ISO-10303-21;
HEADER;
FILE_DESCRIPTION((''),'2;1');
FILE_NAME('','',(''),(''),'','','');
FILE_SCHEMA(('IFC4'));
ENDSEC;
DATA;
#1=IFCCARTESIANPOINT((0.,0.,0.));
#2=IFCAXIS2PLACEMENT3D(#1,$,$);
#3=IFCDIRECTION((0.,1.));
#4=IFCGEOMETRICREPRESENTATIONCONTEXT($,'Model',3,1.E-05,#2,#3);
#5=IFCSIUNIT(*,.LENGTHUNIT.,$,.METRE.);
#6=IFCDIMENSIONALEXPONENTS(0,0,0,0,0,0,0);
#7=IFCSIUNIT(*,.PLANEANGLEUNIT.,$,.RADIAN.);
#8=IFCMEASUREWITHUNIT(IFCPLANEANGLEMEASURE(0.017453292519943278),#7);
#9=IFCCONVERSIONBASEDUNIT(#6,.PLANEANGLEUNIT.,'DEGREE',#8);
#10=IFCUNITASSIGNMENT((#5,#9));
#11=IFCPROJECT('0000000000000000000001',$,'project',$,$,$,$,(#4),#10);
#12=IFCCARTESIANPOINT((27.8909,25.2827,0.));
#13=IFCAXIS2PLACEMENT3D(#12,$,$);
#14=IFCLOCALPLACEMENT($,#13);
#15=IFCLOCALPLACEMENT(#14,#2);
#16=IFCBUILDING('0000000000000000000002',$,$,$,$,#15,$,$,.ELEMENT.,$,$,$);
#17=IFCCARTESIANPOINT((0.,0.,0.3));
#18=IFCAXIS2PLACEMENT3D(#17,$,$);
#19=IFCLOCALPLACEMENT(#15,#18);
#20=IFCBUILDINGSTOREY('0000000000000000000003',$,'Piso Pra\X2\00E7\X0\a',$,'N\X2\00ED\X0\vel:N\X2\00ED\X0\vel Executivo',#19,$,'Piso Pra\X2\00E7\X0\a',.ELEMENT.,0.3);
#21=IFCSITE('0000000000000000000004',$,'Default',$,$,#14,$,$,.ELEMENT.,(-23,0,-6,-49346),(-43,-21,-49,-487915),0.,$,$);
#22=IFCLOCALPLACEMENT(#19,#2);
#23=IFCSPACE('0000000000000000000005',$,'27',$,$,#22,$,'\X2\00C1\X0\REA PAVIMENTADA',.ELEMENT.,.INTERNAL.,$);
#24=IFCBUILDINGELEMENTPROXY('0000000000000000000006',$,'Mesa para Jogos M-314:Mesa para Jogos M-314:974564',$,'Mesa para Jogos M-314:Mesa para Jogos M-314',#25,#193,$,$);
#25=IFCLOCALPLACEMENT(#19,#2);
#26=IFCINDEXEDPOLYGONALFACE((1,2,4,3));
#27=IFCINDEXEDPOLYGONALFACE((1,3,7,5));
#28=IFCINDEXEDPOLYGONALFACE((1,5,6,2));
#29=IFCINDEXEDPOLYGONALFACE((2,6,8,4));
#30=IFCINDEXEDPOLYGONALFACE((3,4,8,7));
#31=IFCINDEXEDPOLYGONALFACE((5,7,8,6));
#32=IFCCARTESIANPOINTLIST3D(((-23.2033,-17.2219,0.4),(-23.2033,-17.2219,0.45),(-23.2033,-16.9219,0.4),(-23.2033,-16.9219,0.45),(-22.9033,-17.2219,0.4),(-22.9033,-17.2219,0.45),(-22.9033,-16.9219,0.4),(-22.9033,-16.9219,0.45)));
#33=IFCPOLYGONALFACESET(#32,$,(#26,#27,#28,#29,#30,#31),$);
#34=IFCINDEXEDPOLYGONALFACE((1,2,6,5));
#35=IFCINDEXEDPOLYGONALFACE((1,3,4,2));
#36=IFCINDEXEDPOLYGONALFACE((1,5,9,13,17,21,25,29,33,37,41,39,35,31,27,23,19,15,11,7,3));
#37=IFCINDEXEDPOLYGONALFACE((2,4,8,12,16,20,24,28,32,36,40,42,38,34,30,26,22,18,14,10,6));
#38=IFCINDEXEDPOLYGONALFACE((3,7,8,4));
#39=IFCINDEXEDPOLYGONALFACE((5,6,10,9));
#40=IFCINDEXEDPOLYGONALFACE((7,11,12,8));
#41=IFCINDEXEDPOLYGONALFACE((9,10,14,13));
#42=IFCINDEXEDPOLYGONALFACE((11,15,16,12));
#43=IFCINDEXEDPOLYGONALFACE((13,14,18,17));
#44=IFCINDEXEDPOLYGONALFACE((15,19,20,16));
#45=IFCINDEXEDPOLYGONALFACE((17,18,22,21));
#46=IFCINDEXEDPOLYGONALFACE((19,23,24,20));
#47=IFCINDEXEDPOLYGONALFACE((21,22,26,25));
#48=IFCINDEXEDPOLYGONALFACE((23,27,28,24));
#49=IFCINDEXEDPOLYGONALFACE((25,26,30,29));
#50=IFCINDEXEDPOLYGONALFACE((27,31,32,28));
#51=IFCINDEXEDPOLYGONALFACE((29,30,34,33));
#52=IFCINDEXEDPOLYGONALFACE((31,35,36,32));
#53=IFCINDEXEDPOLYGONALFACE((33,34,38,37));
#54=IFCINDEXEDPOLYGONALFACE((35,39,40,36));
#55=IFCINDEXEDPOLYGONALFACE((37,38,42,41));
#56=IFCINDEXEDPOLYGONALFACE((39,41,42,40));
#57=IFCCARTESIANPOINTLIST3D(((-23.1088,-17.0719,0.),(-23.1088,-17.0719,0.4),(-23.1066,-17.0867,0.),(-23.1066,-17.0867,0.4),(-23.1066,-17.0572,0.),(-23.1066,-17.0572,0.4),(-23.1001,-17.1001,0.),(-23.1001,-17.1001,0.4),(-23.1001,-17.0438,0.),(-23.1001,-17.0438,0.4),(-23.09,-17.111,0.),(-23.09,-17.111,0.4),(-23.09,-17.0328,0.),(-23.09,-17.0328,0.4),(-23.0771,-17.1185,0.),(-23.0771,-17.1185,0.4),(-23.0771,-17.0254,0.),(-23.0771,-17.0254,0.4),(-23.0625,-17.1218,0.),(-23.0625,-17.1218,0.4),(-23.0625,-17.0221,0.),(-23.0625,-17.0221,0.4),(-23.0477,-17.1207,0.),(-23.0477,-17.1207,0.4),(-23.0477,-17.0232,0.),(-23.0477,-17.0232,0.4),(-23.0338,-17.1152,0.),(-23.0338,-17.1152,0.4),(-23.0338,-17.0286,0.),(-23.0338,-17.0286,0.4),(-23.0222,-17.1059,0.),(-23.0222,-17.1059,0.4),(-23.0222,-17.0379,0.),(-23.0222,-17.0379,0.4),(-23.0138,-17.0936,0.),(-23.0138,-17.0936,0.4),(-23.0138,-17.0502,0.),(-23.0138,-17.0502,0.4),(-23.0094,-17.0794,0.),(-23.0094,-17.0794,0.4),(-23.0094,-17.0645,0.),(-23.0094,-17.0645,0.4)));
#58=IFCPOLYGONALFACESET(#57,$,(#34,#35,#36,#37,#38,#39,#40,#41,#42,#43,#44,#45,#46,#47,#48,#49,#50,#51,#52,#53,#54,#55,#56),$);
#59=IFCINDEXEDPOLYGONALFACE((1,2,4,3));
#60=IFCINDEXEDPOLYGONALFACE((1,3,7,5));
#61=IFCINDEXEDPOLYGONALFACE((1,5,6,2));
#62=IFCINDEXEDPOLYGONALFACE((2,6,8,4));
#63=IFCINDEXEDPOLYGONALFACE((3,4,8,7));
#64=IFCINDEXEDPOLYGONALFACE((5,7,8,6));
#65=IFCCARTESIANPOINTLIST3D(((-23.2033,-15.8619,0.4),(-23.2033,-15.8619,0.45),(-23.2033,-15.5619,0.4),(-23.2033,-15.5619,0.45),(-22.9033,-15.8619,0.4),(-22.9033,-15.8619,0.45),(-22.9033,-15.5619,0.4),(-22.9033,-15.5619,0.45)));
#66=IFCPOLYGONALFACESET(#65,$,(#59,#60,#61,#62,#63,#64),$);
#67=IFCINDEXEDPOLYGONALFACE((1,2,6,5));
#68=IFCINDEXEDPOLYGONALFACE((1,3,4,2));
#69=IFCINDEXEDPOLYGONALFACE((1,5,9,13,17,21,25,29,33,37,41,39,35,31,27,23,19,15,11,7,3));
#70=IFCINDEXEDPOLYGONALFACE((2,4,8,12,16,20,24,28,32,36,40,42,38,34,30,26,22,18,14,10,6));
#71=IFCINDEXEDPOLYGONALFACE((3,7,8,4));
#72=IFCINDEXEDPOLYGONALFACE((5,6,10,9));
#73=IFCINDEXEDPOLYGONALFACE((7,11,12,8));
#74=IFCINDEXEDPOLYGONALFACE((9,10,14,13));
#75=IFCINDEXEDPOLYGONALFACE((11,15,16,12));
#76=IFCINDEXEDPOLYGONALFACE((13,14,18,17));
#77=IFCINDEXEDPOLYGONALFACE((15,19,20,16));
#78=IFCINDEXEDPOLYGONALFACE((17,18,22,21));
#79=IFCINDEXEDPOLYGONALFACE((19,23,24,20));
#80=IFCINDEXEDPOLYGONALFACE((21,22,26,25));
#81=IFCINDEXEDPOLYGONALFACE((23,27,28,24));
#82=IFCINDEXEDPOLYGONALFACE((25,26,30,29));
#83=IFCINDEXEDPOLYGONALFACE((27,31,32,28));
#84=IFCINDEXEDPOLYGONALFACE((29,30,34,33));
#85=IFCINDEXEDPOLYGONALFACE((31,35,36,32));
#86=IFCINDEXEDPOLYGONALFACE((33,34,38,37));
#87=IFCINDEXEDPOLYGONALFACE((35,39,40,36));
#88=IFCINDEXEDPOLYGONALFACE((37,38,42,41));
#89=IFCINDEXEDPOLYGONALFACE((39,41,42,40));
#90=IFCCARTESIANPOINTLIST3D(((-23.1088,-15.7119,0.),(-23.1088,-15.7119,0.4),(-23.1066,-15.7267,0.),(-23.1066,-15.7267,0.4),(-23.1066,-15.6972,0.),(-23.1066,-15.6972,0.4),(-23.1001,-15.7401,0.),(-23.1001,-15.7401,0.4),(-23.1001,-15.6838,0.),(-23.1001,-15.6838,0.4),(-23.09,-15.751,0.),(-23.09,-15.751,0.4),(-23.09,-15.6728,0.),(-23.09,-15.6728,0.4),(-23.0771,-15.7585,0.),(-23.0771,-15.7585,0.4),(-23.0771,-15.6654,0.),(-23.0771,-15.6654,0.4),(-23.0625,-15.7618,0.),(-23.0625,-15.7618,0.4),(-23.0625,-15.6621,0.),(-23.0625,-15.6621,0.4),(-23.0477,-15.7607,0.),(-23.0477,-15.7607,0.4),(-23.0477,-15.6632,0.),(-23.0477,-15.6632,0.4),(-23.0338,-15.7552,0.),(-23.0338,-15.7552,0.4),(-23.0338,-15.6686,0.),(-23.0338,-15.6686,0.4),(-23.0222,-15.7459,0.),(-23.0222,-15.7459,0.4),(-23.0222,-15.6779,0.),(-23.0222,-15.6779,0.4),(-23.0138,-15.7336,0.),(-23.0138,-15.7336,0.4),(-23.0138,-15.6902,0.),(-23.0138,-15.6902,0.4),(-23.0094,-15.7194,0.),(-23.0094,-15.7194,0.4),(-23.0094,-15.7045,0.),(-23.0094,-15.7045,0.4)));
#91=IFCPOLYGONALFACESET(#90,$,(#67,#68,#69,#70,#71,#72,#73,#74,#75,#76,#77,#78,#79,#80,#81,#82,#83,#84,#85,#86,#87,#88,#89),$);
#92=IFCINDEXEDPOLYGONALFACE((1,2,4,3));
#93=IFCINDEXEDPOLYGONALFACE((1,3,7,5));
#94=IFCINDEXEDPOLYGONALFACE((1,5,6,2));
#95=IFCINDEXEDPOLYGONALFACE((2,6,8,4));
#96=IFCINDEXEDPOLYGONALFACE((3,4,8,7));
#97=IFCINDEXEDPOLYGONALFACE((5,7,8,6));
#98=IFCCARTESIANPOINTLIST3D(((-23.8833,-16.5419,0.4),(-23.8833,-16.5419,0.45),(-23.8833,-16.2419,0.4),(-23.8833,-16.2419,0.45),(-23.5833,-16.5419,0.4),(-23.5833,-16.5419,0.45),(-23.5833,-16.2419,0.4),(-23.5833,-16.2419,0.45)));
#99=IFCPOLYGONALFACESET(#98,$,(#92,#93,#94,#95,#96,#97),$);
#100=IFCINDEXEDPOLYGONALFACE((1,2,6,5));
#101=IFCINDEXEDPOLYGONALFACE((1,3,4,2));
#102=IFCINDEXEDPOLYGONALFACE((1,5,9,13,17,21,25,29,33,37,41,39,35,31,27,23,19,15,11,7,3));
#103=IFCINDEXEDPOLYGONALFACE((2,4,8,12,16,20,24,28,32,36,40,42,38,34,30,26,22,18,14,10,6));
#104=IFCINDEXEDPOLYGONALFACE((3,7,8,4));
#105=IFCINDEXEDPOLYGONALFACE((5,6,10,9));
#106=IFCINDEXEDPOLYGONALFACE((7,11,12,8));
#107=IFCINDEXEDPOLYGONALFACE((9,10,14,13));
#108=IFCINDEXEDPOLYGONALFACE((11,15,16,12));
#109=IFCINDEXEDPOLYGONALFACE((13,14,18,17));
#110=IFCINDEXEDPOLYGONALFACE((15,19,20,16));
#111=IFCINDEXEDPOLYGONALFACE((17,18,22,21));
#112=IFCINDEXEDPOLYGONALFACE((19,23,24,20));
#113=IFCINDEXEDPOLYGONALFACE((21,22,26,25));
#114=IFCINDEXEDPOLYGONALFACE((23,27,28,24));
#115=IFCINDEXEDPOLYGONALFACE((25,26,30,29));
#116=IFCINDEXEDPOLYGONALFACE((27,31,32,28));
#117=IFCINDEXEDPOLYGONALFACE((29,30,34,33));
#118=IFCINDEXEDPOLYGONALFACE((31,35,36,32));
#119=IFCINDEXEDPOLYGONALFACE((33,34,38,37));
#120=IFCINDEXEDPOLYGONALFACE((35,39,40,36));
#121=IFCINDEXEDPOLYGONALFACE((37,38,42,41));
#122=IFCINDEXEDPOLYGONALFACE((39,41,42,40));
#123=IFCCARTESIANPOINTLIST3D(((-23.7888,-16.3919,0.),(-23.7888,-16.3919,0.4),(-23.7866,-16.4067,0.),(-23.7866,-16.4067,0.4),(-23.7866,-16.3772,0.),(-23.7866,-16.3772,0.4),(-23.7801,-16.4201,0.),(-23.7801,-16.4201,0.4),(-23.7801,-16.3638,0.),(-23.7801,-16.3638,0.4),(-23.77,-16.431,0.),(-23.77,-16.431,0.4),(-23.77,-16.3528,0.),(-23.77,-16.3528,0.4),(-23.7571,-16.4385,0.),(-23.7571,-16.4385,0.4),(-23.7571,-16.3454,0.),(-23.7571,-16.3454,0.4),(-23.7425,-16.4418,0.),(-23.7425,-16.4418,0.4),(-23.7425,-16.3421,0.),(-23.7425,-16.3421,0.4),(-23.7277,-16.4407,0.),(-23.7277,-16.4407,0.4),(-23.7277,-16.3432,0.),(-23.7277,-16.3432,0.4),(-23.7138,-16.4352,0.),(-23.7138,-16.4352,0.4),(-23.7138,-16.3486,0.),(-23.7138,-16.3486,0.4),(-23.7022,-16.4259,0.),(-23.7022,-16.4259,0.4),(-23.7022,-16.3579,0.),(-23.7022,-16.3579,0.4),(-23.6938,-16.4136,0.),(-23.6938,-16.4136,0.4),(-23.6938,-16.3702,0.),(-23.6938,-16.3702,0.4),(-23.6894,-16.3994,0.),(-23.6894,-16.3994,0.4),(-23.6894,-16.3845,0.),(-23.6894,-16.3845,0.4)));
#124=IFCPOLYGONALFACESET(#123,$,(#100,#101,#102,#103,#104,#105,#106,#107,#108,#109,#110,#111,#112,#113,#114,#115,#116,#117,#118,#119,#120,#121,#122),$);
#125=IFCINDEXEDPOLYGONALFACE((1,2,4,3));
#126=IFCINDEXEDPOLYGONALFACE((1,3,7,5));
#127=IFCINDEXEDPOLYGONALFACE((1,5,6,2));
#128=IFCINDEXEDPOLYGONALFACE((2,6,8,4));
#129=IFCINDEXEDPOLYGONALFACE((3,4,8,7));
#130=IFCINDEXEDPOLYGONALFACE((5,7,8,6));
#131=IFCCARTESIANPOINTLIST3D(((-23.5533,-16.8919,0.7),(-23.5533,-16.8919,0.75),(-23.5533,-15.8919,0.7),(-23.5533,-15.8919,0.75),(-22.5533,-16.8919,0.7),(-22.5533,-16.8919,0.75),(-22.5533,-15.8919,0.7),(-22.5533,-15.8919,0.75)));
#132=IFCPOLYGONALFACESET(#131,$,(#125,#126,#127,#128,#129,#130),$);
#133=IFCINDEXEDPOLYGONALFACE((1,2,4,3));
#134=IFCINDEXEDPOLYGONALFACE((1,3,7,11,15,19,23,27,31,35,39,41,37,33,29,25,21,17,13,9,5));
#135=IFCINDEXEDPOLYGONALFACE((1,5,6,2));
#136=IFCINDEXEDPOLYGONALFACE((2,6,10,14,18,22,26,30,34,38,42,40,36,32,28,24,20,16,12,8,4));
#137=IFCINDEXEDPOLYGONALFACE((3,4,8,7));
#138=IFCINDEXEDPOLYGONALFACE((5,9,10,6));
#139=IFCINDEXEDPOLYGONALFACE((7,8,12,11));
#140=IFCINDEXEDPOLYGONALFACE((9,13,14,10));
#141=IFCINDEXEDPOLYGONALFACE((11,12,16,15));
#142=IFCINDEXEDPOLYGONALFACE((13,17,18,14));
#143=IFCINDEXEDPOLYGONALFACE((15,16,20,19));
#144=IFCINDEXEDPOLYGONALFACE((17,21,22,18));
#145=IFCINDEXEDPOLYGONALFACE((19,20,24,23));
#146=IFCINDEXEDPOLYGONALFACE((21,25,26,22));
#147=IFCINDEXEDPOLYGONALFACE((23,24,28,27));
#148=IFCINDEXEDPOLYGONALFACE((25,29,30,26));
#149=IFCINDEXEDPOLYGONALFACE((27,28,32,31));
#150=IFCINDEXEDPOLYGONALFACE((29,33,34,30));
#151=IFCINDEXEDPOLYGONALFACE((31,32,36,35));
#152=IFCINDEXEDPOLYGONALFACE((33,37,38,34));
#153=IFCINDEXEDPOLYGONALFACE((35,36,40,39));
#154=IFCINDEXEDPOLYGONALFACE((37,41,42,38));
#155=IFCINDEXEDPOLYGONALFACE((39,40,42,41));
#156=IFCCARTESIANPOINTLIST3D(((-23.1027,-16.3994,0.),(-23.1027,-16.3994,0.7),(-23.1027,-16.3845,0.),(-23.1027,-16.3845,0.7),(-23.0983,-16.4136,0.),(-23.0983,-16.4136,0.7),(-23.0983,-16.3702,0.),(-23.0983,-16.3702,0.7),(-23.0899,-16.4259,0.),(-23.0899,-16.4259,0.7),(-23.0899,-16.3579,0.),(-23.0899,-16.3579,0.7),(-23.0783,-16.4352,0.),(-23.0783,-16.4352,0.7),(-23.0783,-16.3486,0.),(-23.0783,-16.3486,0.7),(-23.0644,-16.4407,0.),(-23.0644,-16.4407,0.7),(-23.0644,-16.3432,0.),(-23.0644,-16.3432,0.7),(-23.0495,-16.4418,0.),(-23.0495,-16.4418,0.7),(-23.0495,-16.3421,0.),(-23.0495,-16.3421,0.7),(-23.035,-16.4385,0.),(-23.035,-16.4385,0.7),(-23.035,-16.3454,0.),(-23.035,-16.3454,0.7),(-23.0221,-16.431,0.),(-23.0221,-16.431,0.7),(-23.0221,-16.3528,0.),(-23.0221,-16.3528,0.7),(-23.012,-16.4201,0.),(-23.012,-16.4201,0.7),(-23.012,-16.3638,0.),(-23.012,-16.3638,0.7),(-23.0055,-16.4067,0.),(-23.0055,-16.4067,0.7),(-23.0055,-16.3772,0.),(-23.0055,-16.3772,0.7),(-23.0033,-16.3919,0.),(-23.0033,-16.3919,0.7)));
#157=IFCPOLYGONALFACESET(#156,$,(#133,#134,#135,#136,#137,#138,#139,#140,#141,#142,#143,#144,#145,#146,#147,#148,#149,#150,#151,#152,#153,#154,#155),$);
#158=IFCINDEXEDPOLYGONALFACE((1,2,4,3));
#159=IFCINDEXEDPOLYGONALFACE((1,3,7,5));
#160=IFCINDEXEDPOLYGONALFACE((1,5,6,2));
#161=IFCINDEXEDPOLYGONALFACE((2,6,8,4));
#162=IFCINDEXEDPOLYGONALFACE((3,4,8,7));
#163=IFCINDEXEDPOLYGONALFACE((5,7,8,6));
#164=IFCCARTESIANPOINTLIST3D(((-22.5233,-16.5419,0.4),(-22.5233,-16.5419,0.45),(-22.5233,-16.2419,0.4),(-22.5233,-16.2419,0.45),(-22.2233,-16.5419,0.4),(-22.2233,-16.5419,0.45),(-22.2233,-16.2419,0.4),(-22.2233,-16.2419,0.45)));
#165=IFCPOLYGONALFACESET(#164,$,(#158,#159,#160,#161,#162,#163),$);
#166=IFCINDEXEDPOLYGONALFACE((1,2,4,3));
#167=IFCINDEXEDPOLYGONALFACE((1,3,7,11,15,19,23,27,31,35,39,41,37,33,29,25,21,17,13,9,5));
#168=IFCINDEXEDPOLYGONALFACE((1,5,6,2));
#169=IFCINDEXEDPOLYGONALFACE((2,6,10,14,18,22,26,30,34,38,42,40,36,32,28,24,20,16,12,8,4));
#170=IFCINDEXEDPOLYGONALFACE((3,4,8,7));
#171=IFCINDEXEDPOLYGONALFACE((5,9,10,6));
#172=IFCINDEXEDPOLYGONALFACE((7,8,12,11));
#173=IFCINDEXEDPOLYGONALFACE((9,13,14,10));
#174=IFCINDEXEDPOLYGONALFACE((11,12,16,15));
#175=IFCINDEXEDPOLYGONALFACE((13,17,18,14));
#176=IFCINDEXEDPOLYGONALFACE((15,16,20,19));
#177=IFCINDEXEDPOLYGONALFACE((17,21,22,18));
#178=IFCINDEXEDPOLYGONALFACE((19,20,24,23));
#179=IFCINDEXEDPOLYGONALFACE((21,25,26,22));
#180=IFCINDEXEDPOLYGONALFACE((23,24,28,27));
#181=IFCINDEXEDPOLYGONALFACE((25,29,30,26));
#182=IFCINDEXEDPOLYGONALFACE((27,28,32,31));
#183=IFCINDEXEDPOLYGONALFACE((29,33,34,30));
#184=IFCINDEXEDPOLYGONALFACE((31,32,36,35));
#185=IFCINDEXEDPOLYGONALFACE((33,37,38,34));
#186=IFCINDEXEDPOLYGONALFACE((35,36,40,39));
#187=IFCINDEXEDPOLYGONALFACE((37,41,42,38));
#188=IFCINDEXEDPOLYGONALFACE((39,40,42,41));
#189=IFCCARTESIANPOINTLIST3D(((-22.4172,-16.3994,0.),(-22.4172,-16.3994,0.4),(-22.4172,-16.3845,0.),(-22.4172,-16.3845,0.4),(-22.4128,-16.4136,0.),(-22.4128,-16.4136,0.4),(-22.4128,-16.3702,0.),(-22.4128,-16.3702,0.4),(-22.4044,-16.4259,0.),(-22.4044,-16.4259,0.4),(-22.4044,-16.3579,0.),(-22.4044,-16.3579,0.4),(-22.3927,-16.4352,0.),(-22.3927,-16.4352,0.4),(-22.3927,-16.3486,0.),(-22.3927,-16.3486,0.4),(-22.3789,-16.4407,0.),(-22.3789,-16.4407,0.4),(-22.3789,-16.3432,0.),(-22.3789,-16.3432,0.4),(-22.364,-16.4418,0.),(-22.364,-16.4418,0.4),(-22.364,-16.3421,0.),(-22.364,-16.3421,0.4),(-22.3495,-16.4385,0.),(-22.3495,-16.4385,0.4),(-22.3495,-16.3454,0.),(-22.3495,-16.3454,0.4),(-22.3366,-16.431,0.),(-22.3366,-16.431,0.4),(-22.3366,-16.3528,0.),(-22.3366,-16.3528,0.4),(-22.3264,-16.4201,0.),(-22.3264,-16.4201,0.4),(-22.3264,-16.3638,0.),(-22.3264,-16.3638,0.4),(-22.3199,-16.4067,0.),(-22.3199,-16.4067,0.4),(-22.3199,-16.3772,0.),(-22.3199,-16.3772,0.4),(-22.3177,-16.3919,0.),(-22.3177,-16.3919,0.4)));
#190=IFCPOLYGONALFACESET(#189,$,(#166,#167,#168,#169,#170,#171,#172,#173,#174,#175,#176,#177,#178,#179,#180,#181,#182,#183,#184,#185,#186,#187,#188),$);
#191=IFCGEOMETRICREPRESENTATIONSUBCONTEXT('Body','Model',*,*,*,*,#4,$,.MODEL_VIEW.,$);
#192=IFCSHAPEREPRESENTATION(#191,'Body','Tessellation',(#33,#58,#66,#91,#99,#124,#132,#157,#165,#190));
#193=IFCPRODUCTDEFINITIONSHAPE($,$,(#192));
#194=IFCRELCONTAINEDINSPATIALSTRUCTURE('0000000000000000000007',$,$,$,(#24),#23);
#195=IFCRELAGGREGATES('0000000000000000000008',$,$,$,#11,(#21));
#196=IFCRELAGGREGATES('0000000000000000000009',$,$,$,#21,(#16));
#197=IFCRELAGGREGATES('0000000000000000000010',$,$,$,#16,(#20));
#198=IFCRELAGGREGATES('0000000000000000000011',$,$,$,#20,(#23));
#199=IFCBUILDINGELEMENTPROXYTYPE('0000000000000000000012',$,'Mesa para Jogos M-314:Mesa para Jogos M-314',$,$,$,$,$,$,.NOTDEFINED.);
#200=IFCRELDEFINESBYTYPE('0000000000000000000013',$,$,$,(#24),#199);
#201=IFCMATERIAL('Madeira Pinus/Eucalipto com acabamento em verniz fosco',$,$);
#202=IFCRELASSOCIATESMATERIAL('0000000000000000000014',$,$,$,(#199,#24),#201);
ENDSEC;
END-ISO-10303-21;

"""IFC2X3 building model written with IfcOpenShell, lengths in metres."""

from ifc_helpers import new_model, entity, si_unit, converted_unit, direction, frame, frame_2d, origin, place, context, subcontext, project, spatial, rectangle, circle, extrude, source, transform, mapped, material, type_object, type_shapes, element, save


model = new_model("IFC2X3")

# Units and contexts
model_context = context("Model", 3, precision=1e-05, world=origin(), true_north=direction((0.0, 1.0)))
body_context = subcontext(model_context, "Body", "Model", "MODEL_VIEW")
ifc_project = project(units=[si_unit("LENGTHUNIT", "METRE"), converted_unit("PLANEANGLEUNIT", "DEGREE", entity("IfcPlaneAngleMeasure", 0.017453292519943278), si_unit("PLANEANGLEUNIT", "RADIAN"), dimensions=[0, 0, 0, 0, 0, 0, 0])], contexts=[model_context])

# Site, building, storey
site_placement = place(None, frame((27.8909, 25.2827, 0.0)))
site = spatial("IfcSite", under=ifc_project, at=site_placement, Name="Default", CompositionType="ELEMENT", RefLatitude=(-23, 0, -6, -49346), RefLongitude=(-43, -21, -49, -487915), RefElevation=0.0)
building_placement = place(site_placement, origin())
building = spatial("IfcBuilding", under=site, at=building_placement, CompositionType="ELEMENT")
storey_placement = place(building_placement, frame((0.0, 0.0, 0.3)))
storey = spatial("IfcBuildingStorey", under=building, at=storey_placement, Name="Piso Praça", ObjectType="Nível:Nível Executivo", LongName="Piso Praça", CompositionType="ELEMENT", Elevation=0.3)

# Shared definitions
ifc_material_1 = material(Name="Madeira Pinus/Eucalipto com acabamento em verniz fosco")

# Shared definitions
space_1_placement = place(storey_placement, origin())
space_1 = spatial("IfcSpace", under=storey, at=space_1_placement, Name="27", LongName="ÁREA PAVIMENTADA", CompositionType="ELEMENT", InteriorOrExteriorSpace="INTERNAL")

# Building element proxy
building_element_proxy_type_1 = type_object("IfcBuildingElementProxyType", Name="Mesa para Jogos M-314:Mesa para Jogos M-314", PredefinedType="NOTDEFINED", material=ifc_material_1)
shared_shape_1 = source(origin(), body_context, "Body", "SweptSolid", [
    extrude(rectangle(XDim=0.3, YDim=0.3, at=frame_2d((0.0, 0.0), x_axis=(1.0, 0.0))), frame((0.0, -0.68, 0.4)), (0.0, 0.0, 1.0), 0.05),
    extrude(circle(Radius=0.05, at=frame_2d((0.0, 0.0), x_axis=(1.0, 0.0))), frame((-0.0055, -0.68, 0.0), z_axis=(0.0, 0.0, 1.0), x_axis=(-1.0, 0.0, 0.0)), (0.0, 0.0, 1.0), 0.4),
    extrude(rectangle(XDim=0.3, YDim=0.3, at=frame_2d((0.0, 0.0), x_axis=(1.0, 0.0))), frame((0.0, 0.68, 0.4), z_axis=(0.0, 0.0, 1.0), x_axis=(0.0, -1.0, 0.0)), (0.0, 0.0, 1.0), 0.05),
    extrude(circle(Radius=0.05, at=frame_2d((0.0, 0.0), x_axis=(1.0, 0.0))), frame((-0.0055, 0.68, 0.0), z_axis=(0.0, 0.0, 1.0), x_axis=(-1.0, 0.0, 0.0)), (0.0, 0.0, 1.0), 0.4),
    extrude(rectangle(XDim=0.3, YDim=0.3, at=frame_2d((0.0, 0.0), x_axis=(1.0, 0.0))), frame((-0.68, 0.0, 0.4), z_axis=(0.0, 0.0, 1.0), x_axis=(0.0, -1.0, 0.0)), (0.0, 0.0, 1.0), 0.05),
    extrude(circle(Radius=0.05, at=frame_2d((0.0, 0.0), x_axis=(1.0, 0.0))), frame((-0.6855, 0.0, 0.0), z_axis=(0.0, 0.0, 1.0), x_axis=(-1.0, 0.0, 0.0)), (0.0, 0.0, 1.0), 0.4),
    extrude(rectangle(XDim=1.0, YDim=1.0, at=frame_2d((0.0, 0.0), x_axis=(1.0, 0.0))), frame((0.0, 0.0, 0.7), z_axis=(0.0, 0.0, 1.0), x_axis=(-1.0, 0.0, 0.0)), (0.0, 0.0, 1.0), 0.05),
    extrude(circle(Radius=0.05, at=frame_2d((0.0, 0.0), x_axis=(1.0, 0.0))), origin(), (0.0, 0.0, 1.0), 0.7),
    extrude(rectangle(XDim=0.3, YDim=0.3, at=frame_2d((0.0, 0.0), x_axis=(1.0, 0.0))), frame((0.68, 0.0, 0.4), z_axis=(0.0, 0.0, 1.0), x_axis=(-1.0, 0.0, 0.0)), (0.0, 0.0, 1.0), 0.05),
    extrude(circle(Radius=0.05, at=frame_2d((0.0, 0.0), x_axis=(1.0, 0.0))), frame((0.6855, 0.0, 0.0)), (0.0, 0.0, 1.0), 0.4),
])
type_shapes(building_element_proxy_type_1, [shared_shape_1])
proxy_1_placement = place(space_1_placement, frame((-23.0533, -16.3919, 0.0)))
element("IfcBuildingElementProxy", 1, at=proxy_1_placement, inside=space_1, type_object=building_element_proxy_type_1, material=ifc_material_1, Name="Mesa para Jogos M-314:Mesa para Jogos M-314:974564", ObjectType="Mesa para Jogos M-314:Mesa para Jogos M-314", context=body_context, shape_type="MappedRepresentation", body=[
    mapped(shared_shape_1, transform((0.0, 0.0, 0.0), scale=1.0)),
])

save(model, "model.ifc")
